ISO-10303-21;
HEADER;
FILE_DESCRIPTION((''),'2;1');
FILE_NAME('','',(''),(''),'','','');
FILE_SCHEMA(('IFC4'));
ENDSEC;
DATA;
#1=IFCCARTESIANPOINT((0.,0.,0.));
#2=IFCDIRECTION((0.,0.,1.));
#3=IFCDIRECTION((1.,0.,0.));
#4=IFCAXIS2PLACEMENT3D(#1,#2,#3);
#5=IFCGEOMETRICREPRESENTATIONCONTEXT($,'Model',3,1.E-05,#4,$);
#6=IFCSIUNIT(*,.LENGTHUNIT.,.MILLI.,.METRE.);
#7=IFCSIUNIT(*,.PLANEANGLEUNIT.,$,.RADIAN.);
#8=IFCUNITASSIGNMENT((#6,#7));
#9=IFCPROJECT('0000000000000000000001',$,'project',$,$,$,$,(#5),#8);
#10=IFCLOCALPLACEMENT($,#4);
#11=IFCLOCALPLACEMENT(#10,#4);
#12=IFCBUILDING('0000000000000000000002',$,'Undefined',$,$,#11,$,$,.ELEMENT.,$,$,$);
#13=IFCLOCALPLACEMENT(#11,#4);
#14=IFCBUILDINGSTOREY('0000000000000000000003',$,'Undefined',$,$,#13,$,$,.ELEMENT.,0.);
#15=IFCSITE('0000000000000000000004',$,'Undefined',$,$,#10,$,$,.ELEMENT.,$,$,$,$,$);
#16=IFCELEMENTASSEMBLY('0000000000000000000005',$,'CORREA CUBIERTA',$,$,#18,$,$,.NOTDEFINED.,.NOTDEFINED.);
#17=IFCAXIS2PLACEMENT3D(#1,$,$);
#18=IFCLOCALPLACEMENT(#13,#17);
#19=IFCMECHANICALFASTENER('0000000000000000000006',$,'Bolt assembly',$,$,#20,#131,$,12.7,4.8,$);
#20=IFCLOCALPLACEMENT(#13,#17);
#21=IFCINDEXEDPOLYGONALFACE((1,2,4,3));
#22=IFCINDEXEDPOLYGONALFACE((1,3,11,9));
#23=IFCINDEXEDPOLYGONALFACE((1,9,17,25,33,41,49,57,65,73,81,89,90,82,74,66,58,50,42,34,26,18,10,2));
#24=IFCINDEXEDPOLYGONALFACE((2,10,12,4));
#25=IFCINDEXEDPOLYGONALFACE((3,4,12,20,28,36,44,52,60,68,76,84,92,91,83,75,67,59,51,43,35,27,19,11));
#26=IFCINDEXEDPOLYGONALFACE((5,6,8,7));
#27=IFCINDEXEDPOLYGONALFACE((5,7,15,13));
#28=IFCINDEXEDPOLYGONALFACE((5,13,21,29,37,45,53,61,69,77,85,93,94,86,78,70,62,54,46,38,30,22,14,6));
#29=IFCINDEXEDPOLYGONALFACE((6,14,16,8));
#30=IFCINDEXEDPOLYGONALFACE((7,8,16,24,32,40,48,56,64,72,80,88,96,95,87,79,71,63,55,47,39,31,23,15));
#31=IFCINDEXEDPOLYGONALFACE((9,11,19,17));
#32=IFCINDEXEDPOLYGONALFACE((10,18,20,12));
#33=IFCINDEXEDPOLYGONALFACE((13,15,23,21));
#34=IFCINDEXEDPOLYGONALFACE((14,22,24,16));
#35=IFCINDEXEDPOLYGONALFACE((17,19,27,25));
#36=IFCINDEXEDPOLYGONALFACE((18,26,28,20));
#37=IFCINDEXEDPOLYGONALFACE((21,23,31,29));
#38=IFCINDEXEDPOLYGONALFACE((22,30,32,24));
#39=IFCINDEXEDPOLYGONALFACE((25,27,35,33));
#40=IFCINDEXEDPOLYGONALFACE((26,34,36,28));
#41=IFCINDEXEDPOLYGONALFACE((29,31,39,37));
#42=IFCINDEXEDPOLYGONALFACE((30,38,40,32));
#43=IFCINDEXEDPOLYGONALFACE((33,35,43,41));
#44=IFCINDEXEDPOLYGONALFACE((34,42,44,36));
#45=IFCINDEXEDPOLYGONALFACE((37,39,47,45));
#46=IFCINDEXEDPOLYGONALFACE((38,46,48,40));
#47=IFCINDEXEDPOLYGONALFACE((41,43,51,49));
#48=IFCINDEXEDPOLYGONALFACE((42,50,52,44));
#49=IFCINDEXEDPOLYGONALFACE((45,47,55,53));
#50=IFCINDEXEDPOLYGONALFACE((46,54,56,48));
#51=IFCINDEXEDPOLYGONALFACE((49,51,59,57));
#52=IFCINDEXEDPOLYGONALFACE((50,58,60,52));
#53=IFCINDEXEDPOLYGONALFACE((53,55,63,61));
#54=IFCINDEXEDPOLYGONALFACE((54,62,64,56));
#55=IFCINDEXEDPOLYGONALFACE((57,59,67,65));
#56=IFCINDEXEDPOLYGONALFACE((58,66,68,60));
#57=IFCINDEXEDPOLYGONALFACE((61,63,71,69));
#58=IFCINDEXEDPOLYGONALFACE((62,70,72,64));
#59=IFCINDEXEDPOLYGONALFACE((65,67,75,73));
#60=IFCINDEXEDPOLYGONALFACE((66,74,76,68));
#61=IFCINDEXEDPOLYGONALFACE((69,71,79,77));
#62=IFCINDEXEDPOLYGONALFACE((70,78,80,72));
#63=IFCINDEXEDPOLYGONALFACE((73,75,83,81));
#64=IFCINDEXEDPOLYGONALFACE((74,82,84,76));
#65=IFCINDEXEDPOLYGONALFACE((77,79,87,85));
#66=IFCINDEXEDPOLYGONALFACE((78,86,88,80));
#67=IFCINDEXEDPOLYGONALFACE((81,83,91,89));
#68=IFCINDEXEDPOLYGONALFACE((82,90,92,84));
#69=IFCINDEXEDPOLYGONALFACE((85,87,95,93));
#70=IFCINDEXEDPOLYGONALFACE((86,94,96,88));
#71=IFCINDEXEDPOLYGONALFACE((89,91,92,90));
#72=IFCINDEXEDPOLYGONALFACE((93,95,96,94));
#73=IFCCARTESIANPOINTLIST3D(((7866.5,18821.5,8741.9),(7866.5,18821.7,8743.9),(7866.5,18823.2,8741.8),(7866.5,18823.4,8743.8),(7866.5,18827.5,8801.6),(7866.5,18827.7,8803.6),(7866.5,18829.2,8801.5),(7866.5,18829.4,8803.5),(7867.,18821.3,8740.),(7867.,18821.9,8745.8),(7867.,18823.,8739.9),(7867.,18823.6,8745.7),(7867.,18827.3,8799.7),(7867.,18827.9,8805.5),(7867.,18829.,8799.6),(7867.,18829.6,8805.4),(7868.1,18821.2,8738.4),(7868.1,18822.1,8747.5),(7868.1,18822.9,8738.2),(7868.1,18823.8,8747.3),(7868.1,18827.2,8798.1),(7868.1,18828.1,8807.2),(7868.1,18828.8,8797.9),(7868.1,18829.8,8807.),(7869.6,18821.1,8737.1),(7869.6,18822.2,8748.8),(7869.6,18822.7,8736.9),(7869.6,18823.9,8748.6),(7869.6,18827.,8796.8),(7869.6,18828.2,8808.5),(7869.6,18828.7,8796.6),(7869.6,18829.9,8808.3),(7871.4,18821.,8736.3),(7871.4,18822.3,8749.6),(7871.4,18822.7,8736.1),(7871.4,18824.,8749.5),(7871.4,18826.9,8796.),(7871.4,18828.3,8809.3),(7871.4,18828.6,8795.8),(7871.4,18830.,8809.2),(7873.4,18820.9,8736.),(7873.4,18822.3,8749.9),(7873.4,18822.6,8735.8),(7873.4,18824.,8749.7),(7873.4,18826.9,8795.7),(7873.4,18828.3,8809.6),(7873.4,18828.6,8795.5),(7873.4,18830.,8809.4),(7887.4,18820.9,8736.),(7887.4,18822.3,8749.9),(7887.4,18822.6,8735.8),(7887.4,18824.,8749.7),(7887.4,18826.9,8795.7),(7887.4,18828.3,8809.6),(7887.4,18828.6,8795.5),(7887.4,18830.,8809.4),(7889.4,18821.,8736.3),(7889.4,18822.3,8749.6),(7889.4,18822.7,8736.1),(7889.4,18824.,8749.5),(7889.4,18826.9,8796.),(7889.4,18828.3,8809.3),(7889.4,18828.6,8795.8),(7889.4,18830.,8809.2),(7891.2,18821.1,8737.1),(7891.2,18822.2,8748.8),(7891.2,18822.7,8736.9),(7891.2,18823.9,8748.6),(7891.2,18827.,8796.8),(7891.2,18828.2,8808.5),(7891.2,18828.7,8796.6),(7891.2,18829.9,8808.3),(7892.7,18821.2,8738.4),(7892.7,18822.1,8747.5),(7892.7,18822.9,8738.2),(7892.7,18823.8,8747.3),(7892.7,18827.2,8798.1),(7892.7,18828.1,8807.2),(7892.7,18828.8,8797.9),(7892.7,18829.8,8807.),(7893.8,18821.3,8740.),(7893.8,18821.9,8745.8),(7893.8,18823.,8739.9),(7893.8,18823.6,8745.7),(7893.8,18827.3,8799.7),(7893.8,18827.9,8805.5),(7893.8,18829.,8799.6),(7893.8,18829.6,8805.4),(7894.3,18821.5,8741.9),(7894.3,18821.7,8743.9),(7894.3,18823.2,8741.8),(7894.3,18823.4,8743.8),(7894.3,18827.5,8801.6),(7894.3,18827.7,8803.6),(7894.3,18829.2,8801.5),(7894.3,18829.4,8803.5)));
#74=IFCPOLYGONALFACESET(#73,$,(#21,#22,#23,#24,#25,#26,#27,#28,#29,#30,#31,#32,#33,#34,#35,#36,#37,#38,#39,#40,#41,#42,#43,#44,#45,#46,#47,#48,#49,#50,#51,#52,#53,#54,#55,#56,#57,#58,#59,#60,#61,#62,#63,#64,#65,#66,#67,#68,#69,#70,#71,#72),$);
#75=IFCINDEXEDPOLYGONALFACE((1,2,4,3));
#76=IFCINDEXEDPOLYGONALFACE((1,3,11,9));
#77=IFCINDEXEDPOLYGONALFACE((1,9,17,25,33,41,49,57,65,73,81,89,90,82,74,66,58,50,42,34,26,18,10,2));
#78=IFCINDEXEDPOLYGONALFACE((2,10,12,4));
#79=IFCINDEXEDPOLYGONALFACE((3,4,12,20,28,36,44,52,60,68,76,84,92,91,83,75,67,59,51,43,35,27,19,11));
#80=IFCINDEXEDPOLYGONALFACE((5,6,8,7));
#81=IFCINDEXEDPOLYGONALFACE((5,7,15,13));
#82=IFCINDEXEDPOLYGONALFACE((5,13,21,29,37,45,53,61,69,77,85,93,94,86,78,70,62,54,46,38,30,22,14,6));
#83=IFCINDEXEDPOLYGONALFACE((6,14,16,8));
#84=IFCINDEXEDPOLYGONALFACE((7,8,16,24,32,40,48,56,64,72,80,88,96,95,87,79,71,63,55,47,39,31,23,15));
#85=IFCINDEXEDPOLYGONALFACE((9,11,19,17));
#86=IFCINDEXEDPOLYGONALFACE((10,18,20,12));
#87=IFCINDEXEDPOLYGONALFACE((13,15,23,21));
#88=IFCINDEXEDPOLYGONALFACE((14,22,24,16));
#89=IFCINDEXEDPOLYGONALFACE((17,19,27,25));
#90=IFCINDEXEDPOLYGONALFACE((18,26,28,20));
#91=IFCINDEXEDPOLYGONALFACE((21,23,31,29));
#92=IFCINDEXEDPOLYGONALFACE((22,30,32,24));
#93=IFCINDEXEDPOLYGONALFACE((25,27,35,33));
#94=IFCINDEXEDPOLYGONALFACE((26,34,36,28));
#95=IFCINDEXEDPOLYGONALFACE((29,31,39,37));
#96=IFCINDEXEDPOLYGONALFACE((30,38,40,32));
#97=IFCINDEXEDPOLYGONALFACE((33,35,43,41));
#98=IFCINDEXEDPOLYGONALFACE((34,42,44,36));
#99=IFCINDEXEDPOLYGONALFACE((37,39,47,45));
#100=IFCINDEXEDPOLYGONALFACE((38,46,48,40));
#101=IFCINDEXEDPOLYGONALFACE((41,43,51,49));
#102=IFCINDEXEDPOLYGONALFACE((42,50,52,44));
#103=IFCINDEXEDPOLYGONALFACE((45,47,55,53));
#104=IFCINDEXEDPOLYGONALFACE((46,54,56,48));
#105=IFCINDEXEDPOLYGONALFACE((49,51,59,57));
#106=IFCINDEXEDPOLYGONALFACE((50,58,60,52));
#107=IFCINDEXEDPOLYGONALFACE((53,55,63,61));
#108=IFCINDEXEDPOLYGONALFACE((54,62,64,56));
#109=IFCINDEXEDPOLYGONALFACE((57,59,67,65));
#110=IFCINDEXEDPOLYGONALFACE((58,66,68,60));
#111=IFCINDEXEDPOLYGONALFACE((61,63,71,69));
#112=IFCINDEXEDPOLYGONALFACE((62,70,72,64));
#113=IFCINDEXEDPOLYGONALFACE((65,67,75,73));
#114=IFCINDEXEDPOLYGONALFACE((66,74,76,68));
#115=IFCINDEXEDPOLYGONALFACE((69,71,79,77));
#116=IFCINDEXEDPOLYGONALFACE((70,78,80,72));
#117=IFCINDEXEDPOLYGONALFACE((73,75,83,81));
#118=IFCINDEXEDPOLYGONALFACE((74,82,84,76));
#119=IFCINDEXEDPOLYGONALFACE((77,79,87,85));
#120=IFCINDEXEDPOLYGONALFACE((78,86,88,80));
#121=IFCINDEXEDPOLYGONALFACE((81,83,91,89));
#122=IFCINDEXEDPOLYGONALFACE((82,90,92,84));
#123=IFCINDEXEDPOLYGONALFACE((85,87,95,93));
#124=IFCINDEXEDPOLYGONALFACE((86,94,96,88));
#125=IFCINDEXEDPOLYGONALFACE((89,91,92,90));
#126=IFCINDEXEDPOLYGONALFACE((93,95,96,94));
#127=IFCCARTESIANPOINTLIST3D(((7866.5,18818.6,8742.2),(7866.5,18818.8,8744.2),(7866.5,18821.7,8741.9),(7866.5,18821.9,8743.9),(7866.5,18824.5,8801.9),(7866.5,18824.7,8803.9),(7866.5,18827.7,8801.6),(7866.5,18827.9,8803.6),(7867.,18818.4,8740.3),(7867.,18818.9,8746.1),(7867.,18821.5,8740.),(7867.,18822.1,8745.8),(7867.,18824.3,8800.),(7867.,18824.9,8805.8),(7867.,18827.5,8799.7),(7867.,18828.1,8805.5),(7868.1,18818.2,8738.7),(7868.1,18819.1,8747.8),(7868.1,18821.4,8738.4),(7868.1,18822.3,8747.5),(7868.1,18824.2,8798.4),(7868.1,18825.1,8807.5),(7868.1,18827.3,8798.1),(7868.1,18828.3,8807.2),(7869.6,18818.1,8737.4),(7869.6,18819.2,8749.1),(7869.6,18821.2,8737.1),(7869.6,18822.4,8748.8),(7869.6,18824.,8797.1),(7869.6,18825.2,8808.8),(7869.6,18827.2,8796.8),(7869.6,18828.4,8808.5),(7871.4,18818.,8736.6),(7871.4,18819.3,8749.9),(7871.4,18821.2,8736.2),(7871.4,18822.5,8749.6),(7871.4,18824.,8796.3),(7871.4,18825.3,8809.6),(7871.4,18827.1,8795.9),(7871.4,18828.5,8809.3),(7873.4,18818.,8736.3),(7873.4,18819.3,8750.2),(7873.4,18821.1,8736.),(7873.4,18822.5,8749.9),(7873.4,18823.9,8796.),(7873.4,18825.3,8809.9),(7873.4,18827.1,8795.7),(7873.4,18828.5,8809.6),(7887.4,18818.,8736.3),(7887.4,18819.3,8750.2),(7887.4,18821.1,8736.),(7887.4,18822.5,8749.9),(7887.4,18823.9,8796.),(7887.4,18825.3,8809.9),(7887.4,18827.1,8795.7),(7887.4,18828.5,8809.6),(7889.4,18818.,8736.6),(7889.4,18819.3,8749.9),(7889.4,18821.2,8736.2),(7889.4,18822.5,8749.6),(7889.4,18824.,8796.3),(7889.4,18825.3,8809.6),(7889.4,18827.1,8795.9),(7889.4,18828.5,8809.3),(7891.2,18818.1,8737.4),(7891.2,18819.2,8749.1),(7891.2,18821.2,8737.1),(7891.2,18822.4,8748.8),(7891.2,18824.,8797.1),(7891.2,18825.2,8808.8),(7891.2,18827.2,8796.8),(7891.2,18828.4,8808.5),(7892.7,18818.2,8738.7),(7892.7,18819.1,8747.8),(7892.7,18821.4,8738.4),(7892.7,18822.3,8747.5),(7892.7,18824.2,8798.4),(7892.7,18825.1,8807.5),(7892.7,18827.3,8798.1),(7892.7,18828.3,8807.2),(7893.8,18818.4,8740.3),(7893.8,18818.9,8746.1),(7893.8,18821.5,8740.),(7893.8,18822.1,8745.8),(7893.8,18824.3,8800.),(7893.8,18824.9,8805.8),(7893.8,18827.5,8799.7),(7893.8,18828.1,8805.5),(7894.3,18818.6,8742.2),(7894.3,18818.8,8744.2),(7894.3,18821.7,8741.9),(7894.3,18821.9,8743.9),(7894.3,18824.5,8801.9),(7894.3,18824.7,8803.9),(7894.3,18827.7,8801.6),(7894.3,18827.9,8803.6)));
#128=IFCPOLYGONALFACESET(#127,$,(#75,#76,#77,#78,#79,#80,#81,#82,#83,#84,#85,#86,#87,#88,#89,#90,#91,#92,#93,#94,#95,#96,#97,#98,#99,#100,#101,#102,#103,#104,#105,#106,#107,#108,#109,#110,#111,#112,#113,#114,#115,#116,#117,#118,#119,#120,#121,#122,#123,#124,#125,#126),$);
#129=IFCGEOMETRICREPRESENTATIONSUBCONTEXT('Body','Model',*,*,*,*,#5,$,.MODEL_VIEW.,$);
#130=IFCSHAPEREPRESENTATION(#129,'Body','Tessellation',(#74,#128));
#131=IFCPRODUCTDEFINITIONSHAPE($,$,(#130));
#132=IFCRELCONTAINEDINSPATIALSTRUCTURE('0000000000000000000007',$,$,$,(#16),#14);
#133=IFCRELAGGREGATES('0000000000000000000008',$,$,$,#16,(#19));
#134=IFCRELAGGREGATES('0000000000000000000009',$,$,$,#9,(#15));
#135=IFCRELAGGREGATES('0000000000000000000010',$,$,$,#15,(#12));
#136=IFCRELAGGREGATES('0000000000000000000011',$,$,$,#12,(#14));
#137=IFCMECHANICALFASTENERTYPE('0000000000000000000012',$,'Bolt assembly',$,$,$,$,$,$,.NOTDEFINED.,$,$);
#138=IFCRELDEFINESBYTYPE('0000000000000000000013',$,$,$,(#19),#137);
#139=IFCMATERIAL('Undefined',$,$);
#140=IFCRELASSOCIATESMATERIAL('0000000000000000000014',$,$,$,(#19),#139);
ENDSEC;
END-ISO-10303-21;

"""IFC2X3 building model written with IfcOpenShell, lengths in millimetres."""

from ifc_helpers import new_model, entity, si_unit, frame, origin_with_axes, place, context, subcontext, project, spatial, source, transform, mapped, material, type_object, element, aggregate, save


model = new_model("IFC2X3")

# Units and contexts
model_context = context("Model", 3, precision=1e-05, world=origin_with_axes())
body_context = subcontext(model_context, "Body", "Model", "MODEL_VIEW")
ifc_project = project(units=[si_unit("LENGTHUNIT", "METRE", prefix="MILLI"), si_unit("PLANEANGLEUNIT", "RADIAN")], contexts=[model_context])

# Site, building, storey
site_placement = place(None, origin_with_axes())
site = spatial("IfcSite", under=ifc_project, at=site_placement, Name="Undefined", CompositionType="ELEMENT")
building_placement = place(site_placement, origin_with_axes())
building = spatial("IfcBuilding", under=site, at=building_placement, Name="Undefined", CompositionType="ELEMENT")
storey_placement = place(building_placement, origin_with_axes())
storey = spatial("IfcBuildingStorey", under=building, at=storey_placement, Name="Undefined", CompositionType="ELEMENT", Elevation=0.0)

# Element assembly, mechanical fastener
ifc_material_1 = material(Name="Undefined")
mechanical_fastener_type = type_object("IfcMechanicalFastenerType", Name="Bolt assembly")
shared_circle_1 = entity("IfcCircle", entity("IfcAxis2Placement2D", entity("IfcCartesianPoint", [0.0, -7.0]), entity("IfcDirection", [1.0, 0.0])), 7.0)
shared_circle_2 = entity("IfcCircle", entity("IfcAxis2Placement2D", entity("IfcCartesianPoint", [0.0, 7.0]), entity("IfcDirection", [-1.0, 0.0])), 7.0)
shared_composite_curve = entity("IfcCompositeCurve", [entity("IfcCompositeCurveSegment", "CONTINUOUS", True, entity("IfcPolyline", [entity("IfcCartesianPoint", [7.0, 7.0]), entity("IfcCartesianPoint", [7.0, -7.0])])), entity("IfcCompositeCurveSegment", "CONTINUOUS", True, entity("IfcTrimmedCurve", shared_circle_1, [entity("IfcParameterValue", 0.0)], [entity("IfcParameterValue", 3.141593)], False, "PARAMETER")), entity("IfcCompositeCurveSegment", "CONTINUOUS", True, entity("IfcPolyline", [entity("IfcCartesianPoint", [-7.0, -7.0]), entity("IfcCartesianPoint", [-7.0, 7.0])])), entity("IfcCompositeCurveSegment", "DISCONTINUOUS", True, entity("IfcTrimmedCurve", shared_circle_2, [entity("IfcParameterValue", 0.0)], [entity("IfcParameterValue", 3.141593)], False, "PARAMETER"))], False)
assembly_1_placement = place(storey_placement, origin_with_axes())
assembly_1 = element("IfcElementAssembly", 1, at=assembly_1_placement, inside=storey, Name="CORREA CUBIERTA", AssemblyPlace="NOTDEFINED", PredefinedType="NOTDEFINED")
shared_shape_1 = source(origin_with_axes(), body_context, "Body", "SweptSolid", [
    entity("IfcExtrudedAreaSolid", entity("IfcArbitraryClosedProfileDef", "AREA", None, shared_composite_curve), entity("IfcAxis2Placement3D", entity("IfcCartesianPoint", [0.0, 3.1, 0.0]), entity("IfcDirection", [0.0, 1.0, 0.0]), entity("IfcDirection", [1.0, 0.0, 0.0])), entity("IfcDirection", [0.0, 0.0, 1.0]), 1.7),
    entity("IfcExtrudedAreaSolid", entity("IfcArbitraryClosedProfileDef", "AREA", None, shared_composite_curve), entity("IfcAxis2Placement3D", entity("IfcCartesianPoint", [0.0, 0.1, 0.0]), entity("IfcDirection", [0.0, 1.0, 0.0]), entity("IfcDirection", [1.0, 0.0, 0.0])), entity("IfcDirection", [0.0, 0.0, 1.0]), 3.2),
])
mechanical_fastener_1_placement = place(assembly_1_placement, frame((7880.4, 18824.5, 8802.9), z_axis=(1.0, 0.0, 0.0), x_axis=(0.0, -0.099503, -0.995037)))
mechanical_fastener_1 = element("IfcMechanicalFastener", 2, at=mechanical_fastener_1_placement, type_object=mechanical_fastener_type, material=ifc_material_1, Name="Bolt assembly", NominalDiameter=12.7, NominalLength=4.8, context=body_context, shape_type="MappedRepresentation", body=[
    mapped(shared_shape_1, transform((0.0, 0.0, 0.0))),
    mapped(shared_shape_1, transform((60.0, 0.0, 0.0))),
])

aggregate(assembly_1, [mechanical_fastener_1])

save(model, "model.ifc")
